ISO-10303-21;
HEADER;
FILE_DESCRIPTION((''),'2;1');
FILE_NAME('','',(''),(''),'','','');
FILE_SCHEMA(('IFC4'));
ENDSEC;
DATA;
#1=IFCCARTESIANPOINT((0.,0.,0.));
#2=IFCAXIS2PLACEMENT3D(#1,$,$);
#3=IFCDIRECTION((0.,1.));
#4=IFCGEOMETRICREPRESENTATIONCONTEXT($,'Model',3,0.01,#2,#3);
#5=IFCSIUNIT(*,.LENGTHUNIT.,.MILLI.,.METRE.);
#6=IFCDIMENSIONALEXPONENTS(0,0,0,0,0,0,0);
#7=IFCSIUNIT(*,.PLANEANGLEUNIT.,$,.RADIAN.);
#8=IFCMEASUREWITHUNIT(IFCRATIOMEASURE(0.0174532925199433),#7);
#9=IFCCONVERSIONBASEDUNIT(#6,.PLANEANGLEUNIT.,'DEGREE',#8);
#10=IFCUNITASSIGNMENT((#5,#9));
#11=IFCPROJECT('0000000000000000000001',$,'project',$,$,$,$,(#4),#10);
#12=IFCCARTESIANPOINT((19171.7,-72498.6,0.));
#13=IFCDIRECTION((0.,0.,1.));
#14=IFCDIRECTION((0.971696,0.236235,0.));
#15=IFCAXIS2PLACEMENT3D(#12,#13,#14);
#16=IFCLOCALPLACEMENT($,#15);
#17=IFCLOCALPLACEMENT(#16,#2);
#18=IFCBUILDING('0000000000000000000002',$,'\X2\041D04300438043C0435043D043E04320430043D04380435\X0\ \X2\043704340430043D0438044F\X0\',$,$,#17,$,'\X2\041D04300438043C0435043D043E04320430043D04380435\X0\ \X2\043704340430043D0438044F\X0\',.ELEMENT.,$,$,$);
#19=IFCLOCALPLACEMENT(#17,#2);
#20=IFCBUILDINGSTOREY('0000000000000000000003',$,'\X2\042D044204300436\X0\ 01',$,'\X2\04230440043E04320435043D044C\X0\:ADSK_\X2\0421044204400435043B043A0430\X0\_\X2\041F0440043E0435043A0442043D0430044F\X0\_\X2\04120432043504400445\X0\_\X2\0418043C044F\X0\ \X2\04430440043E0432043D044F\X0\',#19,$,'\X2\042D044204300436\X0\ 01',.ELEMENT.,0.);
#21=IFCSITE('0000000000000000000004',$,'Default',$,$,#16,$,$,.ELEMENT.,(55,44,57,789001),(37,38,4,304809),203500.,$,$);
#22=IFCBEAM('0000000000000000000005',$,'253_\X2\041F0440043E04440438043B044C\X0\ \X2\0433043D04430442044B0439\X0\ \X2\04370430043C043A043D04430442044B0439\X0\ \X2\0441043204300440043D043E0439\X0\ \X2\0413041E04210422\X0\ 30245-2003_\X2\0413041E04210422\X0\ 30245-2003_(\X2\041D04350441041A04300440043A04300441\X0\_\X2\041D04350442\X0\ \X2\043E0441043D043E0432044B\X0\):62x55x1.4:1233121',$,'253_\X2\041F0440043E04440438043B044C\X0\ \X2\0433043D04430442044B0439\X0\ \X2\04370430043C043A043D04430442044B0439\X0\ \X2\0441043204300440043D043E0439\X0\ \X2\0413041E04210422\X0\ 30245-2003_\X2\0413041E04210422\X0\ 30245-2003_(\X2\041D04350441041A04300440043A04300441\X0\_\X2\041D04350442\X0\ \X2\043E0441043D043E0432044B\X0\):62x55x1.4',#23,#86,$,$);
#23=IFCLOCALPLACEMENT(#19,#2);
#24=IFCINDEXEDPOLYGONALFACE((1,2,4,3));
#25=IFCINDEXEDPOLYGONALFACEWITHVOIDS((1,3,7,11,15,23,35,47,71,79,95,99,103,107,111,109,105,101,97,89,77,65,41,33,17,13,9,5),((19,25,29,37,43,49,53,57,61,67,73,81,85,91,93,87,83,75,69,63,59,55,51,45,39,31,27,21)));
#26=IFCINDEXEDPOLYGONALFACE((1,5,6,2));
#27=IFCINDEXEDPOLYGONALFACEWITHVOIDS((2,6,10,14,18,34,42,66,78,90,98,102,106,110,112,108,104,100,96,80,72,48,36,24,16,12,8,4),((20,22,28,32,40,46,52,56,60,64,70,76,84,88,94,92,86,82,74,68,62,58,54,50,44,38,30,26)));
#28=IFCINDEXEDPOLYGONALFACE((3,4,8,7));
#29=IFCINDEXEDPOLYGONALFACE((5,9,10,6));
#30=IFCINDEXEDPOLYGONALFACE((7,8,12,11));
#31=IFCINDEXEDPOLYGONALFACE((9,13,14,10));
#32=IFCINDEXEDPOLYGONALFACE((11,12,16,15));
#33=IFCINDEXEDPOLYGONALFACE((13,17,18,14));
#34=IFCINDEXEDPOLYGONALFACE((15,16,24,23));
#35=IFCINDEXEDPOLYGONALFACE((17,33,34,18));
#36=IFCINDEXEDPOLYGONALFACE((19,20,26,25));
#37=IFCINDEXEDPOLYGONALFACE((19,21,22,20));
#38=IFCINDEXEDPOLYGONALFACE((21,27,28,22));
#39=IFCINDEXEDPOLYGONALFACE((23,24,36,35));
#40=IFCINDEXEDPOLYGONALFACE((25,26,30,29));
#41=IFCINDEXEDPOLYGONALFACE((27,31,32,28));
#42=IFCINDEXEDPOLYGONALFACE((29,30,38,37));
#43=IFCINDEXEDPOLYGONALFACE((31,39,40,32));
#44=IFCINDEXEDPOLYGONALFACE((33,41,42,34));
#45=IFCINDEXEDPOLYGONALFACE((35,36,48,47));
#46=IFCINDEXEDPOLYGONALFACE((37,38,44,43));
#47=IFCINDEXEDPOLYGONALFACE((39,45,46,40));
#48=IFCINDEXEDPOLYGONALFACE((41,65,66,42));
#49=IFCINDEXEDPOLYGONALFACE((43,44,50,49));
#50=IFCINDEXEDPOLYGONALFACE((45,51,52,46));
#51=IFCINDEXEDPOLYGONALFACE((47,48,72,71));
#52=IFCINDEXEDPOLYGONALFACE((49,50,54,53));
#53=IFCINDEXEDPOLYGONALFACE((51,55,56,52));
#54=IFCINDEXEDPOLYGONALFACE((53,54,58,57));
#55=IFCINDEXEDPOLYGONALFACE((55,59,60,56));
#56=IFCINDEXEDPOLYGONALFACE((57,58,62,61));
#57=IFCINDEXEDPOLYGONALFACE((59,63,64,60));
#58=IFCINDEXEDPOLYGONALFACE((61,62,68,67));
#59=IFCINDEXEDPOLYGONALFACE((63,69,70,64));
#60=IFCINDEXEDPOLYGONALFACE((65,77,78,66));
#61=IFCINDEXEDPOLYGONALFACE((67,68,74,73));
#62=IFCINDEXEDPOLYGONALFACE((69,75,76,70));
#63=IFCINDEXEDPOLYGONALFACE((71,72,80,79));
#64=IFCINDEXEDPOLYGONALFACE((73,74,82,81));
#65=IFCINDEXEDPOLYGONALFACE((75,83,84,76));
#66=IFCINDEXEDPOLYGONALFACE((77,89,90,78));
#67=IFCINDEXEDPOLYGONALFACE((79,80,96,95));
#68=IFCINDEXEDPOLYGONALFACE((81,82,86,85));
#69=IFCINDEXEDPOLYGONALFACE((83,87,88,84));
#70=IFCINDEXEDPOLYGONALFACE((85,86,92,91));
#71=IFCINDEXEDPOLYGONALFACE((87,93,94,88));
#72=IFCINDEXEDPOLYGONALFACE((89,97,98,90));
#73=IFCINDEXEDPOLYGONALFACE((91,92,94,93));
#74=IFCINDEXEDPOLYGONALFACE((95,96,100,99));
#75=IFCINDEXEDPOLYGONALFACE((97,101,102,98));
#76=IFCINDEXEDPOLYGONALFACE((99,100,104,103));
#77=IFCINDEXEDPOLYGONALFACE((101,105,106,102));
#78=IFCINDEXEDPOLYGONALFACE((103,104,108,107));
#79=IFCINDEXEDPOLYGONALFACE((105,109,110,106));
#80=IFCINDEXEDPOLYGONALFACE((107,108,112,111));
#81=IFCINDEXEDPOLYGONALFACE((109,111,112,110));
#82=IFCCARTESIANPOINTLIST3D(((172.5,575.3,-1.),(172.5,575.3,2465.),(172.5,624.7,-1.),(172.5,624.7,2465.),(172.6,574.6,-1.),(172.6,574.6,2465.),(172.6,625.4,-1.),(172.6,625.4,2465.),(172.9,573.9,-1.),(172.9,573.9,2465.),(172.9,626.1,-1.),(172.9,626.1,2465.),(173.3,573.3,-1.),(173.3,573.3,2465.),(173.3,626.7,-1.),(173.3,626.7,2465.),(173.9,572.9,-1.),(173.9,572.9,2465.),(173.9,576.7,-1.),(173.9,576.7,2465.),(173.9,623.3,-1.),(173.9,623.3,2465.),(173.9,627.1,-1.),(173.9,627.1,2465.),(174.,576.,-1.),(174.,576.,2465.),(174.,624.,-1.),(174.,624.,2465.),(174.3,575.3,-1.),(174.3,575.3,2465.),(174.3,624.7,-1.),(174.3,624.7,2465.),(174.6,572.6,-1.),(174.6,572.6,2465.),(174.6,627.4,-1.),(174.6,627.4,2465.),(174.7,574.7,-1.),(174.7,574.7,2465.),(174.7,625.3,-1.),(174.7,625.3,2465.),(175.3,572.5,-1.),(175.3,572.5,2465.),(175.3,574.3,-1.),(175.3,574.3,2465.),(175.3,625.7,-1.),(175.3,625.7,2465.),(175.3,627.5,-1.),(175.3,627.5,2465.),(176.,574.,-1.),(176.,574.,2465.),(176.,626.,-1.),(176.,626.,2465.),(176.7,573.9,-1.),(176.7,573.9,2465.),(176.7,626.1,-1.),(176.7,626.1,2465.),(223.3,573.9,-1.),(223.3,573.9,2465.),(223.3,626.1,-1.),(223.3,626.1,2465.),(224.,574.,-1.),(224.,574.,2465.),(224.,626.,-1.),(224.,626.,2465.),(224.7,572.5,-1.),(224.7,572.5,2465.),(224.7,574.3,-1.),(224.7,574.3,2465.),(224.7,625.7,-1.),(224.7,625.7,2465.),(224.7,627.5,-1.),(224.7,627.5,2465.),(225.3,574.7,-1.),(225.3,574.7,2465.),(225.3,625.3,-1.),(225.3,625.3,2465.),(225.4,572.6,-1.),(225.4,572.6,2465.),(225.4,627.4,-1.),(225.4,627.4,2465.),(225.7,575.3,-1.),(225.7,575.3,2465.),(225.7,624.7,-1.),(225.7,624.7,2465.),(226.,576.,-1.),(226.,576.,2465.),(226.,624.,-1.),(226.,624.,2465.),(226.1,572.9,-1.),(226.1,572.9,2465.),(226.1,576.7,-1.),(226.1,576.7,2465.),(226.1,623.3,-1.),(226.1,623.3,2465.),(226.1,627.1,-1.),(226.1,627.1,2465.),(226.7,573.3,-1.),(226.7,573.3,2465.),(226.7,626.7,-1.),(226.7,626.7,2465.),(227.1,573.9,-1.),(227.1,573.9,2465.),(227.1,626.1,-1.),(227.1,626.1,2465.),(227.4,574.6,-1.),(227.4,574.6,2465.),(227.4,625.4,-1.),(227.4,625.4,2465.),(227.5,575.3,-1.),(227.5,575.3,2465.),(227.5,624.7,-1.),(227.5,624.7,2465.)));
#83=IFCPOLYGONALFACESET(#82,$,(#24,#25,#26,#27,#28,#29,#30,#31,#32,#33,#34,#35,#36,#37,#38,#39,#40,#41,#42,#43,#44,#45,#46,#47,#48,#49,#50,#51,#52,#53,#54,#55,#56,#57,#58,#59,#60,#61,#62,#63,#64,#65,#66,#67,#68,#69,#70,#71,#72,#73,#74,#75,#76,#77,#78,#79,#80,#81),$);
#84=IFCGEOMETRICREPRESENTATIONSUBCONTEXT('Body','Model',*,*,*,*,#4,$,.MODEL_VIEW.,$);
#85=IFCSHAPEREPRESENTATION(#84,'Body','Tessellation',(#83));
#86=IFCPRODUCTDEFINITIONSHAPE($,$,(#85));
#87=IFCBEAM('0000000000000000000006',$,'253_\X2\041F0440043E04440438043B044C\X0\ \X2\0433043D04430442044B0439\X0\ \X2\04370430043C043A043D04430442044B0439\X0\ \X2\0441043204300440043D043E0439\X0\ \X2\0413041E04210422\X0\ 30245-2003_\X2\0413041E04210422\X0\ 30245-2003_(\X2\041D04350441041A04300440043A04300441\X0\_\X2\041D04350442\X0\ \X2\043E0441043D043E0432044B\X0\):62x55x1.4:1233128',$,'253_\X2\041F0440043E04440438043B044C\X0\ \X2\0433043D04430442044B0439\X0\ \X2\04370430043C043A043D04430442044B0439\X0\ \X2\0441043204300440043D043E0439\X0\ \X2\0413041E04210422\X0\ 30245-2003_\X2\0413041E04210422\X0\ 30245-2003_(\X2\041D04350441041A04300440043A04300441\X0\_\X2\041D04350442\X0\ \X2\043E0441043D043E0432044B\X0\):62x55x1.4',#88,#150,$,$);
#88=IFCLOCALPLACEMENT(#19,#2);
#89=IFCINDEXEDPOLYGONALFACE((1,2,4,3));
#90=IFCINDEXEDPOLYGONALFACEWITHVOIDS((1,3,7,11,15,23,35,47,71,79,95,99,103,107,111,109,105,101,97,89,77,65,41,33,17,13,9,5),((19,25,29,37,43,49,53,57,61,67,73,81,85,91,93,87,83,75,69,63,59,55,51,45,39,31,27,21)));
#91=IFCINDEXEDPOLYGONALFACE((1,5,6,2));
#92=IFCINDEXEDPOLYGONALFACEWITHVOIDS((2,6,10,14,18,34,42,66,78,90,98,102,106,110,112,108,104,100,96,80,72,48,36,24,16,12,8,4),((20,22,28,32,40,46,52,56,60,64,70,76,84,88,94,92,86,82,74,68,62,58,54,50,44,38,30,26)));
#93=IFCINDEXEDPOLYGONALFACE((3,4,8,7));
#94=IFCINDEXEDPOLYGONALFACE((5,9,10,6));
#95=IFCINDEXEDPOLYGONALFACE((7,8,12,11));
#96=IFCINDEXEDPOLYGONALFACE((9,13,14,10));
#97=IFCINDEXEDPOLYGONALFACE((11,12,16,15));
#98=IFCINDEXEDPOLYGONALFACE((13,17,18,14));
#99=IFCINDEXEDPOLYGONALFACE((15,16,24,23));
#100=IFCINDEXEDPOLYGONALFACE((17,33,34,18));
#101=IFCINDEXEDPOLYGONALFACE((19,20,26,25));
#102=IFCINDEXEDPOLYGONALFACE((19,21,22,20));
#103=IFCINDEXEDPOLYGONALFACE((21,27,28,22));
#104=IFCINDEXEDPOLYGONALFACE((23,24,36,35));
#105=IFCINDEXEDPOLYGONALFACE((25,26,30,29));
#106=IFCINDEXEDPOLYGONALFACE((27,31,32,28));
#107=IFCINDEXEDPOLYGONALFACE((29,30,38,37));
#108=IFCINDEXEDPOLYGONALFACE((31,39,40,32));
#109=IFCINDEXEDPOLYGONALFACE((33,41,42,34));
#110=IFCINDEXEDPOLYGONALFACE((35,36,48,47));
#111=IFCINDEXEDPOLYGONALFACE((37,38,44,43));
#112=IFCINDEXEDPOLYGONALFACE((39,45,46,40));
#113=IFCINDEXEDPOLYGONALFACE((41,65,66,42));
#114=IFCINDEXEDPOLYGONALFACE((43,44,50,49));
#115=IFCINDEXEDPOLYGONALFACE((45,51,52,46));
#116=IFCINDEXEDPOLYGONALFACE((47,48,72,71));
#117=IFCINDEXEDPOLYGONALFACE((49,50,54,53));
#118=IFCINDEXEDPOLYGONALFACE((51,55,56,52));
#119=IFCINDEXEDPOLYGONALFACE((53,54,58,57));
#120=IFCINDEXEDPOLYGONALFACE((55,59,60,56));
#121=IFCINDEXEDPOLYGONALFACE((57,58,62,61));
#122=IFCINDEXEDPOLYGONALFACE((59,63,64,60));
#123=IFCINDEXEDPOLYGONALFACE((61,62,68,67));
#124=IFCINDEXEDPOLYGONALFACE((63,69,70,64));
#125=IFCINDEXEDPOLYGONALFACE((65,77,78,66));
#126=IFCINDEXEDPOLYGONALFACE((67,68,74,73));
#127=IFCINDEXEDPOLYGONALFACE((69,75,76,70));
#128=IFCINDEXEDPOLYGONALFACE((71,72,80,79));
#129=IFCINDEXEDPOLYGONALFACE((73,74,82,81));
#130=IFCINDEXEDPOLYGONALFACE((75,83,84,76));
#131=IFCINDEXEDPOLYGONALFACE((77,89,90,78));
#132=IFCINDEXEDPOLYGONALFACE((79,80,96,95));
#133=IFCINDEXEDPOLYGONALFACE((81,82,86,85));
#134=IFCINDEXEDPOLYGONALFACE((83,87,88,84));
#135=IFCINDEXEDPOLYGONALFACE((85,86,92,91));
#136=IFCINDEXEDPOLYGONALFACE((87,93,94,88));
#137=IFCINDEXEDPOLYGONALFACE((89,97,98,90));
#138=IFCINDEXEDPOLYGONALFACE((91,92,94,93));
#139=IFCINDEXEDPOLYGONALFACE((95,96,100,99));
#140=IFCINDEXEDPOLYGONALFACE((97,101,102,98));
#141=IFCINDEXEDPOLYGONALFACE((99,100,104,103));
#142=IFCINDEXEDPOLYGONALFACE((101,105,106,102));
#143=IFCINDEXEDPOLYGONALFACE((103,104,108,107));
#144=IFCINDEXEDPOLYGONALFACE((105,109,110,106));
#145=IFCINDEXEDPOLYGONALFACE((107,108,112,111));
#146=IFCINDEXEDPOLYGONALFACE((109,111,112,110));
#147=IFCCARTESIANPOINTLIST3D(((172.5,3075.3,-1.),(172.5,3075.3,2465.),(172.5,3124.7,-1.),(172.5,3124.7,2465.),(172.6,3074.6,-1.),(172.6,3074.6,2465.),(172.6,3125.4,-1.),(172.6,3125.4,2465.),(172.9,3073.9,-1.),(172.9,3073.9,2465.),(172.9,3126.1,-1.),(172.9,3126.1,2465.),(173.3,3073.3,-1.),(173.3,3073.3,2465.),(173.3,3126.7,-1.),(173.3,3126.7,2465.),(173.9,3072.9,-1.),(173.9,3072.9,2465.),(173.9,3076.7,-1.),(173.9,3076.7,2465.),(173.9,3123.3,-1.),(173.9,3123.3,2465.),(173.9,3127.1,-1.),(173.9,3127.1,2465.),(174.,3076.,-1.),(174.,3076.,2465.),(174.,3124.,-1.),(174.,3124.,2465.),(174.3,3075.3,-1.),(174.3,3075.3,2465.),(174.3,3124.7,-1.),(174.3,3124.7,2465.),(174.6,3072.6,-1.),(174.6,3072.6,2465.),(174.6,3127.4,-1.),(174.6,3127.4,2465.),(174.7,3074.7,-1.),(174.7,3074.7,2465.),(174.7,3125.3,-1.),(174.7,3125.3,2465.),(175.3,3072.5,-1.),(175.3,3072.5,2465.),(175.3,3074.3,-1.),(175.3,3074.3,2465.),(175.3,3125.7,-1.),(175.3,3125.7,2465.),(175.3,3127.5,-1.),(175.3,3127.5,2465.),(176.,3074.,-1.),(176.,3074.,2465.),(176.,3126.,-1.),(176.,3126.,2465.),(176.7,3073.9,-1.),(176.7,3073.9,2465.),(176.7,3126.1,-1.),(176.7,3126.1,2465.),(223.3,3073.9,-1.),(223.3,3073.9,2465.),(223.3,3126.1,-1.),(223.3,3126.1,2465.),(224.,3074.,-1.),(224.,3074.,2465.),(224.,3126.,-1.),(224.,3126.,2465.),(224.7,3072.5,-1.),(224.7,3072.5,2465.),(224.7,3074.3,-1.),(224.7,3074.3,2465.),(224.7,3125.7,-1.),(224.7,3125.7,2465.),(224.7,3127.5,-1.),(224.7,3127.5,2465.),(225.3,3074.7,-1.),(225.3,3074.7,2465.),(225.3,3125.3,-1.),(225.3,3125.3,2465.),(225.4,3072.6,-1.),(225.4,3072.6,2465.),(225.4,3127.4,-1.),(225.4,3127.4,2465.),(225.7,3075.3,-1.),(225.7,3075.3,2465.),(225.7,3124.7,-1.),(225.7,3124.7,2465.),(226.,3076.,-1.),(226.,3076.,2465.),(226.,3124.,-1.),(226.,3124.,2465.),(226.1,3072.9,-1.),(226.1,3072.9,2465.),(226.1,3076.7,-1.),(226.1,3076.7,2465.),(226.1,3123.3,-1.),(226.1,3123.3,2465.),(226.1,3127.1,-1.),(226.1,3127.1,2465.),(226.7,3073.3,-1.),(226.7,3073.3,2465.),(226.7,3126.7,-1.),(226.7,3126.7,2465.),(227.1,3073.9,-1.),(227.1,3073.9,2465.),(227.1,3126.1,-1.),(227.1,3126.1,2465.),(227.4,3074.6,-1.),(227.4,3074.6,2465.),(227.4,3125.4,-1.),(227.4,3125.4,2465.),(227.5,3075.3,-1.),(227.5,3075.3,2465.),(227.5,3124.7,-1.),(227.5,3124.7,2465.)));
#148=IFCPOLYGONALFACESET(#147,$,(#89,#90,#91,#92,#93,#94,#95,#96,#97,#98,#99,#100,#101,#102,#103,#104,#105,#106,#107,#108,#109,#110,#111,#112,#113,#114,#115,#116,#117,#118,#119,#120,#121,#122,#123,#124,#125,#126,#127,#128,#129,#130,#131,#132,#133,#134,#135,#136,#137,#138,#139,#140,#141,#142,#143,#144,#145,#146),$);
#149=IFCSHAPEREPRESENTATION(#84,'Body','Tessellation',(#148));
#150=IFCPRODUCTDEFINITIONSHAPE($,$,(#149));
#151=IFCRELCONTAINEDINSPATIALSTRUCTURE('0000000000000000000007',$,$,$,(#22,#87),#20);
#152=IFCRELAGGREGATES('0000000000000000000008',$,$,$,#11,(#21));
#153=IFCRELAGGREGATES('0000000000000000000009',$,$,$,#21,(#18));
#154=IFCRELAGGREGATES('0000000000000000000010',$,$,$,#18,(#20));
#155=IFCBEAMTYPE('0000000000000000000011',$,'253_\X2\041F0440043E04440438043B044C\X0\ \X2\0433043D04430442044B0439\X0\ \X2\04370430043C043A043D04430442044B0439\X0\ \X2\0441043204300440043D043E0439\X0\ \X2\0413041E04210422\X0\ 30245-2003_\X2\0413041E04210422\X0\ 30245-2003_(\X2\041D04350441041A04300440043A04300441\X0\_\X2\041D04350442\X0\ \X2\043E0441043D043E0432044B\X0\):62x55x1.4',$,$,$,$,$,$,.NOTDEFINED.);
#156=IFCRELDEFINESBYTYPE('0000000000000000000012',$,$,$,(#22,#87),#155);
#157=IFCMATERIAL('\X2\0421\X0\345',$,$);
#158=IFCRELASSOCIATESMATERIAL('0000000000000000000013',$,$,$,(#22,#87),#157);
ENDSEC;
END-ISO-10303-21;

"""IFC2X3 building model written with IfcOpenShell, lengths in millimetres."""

from ifc_helpers import new_model, entity, si_unit, converted_unit, direction, frame, frame_2d, origin, place, context, subcontext, project, spatial, polyline, circle_curve, parameter, trimmed, segment, composite_curve, outline, extrude, material, type_object, element, save


model = new_model("IFC2X3")

# Units and contexts
model_context = context("Model", 3, precision=0.01, world=origin(), true_north=direction((0.0, 1.0)))
body_context = subcontext(model_context, "Body", "Model", "MODEL_VIEW")
ifc_project = project(units=[si_unit("LENGTHUNIT", "METRE", prefix="MILLI"), converted_unit("PLANEANGLEUNIT", "DEGREE", entity("IfcRatioMeasure", 0.0174532925199433), si_unit("PLANEANGLEUNIT", "RADIAN"), dimensions=[0, 0, 0, 0, 0, 0, 0])], contexts=[model_context])

# Site, building, storey
site_placement = place(None, frame((19171.7, -72498.6, 0.0), z_axis=(0.0, 0.0, 1.0), x_axis=(0.971696, 0.236235, 0.0)))
site = spatial("IfcSite", under=ifc_project, at=site_placement, Name="Default", CompositionType="ELEMENT", RefLatitude=(55, 44, 57, 789001), RefLongitude=(37, 38, 4, 304809), RefElevation=203500.0)
building_placement = place(site_placement, origin())
building = spatial("IfcBuilding", under=site, at=building_placement, Name="Наименование здания", LongName="Наименование здания", CompositionType="ELEMENT")
storey_placement = place(building_placement, origin())
storey = spatial("IfcBuildingStorey", under=building, at=storey_placement, Name="Этаж 01", ObjectType="Уровень:ADSK_Стрелка_Проектная_Вверх_Имя уровня", LongName="Этаж 01", CompositionType="ELEMENT", Elevation=0.0)

# Beams
ifc_material_1 = material(Name="С345")
beam_type_1 = type_object("IfcBeamType", Name="253_Профиль гнутый замкнутый сварной ГОСТ 30245-2003_ГОСТ 30245-2003_(НесКаркас_Нет основы):62x55x1.4", PredefinedType="NOTDEFINED")
beam_1_placement = place(storey_placement, frame((170.9, 570.9, -1.0), z_axis=(1.0, 0.0, 0.0), x_axis=(0.0, 0.0, 1.0)))
element("IfcBeam", 1, at=beam_1_placement, inside=storey, type_object=beam_type_1, material=ifc_material_1, Name="253_Профиль гнутый замкнутый сварной ГОСТ 30245-2003_ГОСТ 30245-2003_(НесКаркас_Нет основы):62x55x1.4:1233121", ObjectType="253_Профиль гнутый замкнутый сварной ГОСТ 30245-2003_ГОСТ 30245-2003_(НесКаркас_Нет основы):62x55x1.4", context=body_context, shape_type="SweptSolid", body=[
    extrude(outline(composite_curve([segment(trimmed(circle_curve(frame_2d((24.7, -24.7), x_axis=(1.0, 0.0)), 2.8), [parameter(270.0)], [parameter(0.0)], True, "PARAMETER"), True, "CONTINUOUS"), segment(polyline([(27.5, -24.7), (27.5, 24.7)]), True, "CONTINUOUS"), segment(trimmed(circle_curve(frame_2d((24.7, 24.7), x_axis=(1.0, 0.0)), 2.8), [parameter(0.0)], [parameter(90.0)], True, "PARAMETER"), True, "CONTINUOUS"), segment(polyline([(24.7, 27.5), (-24.7, 27.5)]), True, "CONTINUOUS"), segment(trimmed(circle_curve(frame_2d((-24.7, 24.7), x_axis=(1.0, 0.0)), 2.8), [parameter(90.0)], [parameter(180.0)], True, "PARAMETER"), True, "CONTINUOUS"), segment(polyline([(-27.5, 24.7), (-27.5, -24.7)]), True, "CONTINUOUS"), segment(trimmed(circle_curve(frame_2d((-24.7, -24.7), x_axis=(1.0, 0.0)), 2.8), [parameter(180.0)], [parameter(270.0)], True, "PARAMETER"), True, "CONTINUOUS"), segment(polyline([(-24.7, -27.5), (24.7, -27.5)]), True, "CONTINUOUS")], self_intersect=False), holes=[composite_curve([segment(polyline([(23.3, -26.1), (-23.3, -26.1)]), True, "CONTINUOUS"), segment(trimmed(circle_curve(frame_2d((-23.3, -23.3), x_axis=(1.0, 0.0)), 2.8), [parameter(180.0)], [parameter(270.0)], True, "PARAMETER"), False, "CONTINUOUS"), segment(polyline([(-26.1, -23.3), (-26.1, 23.3)]), True, "CONTINUOUS"), segment(trimmed(circle_curve(frame_2d((-23.3, 23.3), x_axis=(1.0, 0.0)), 2.8), [parameter(90.0)], [parameter(180.0)], True, "PARAMETER"), False, "CONTINUOUS"), segment(polyline([(-23.3, 26.1), (23.3, 26.1)]), True, "CONTINUOUS"), segment(trimmed(circle_curve(frame_2d((23.3, 23.3), x_axis=(1.0, 0.0)), 2.8), [parameter(0.0)], [parameter(90.0)], True, "PARAMETER"), False, "CONTINUOUS"), segment(polyline([(26.1, 23.3), (26.1, -23.3)]), True, "CONTINUOUS"), segment(trimmed(circle_curve(frame_2d((23.3, -23.3), x_axis=(1.0, 0.0)), 2.8), [parameter(270.0)], [parameter(0.0)], True, "PARAMETER"), False, "CONTINUOUS")], self_intersect=False)]), frame((0.0, -29.1, 29.1), z_axis=(1.0, 0.0, 0.0), x_axis=(0.0, -1.0, 0.0)), (0.0, 0.0, 1.0), 2466.0),
])
beam_2_placement = place(storey_placement, frame((170.9, 3070.9, -1.0), z_axis=(1.0, 0.0, 0.0), x_axis=(0.0, 0.0, 1.0)))
element("IfcBeam", 2, at=beam_2_placement, inside=storey, type_object=beam_type_1, material=ifc_material_1, Name="253_Профиль гнутый замкнутый сварной ГОСТ 30245-2003_ГОСТ 30245-2003_(НесКаркас_Нет основы):62x55x1.4:1233128", ObjectType="253_Профиль гнутый замкнутый сварной ГОСТ 30245-2003_ГОСТ 30245-2003_(НесКаркас_Нет основы):62x55x1.4", context=body_context, shape_type="SweptSolid", body=[
    extrude(outline(composite_curve([segment(trimmed(circle_curve(frame_2d((24.7, -24.7), x_axis=(1.0, 0.0)), 2.8), [parameter(270.0)], [parameter(0.0)], True, "PARAMETER"), True, "CONTINUOUS"), segment(polyline([(27.5, -24.7), (27.5, 24.7)]), True, "CONTINUOUS"), segment(trimmed(circle_curve(frame_2d((24.7, 24.7), x_axis=(1.0, 0.0)), 2.8), [parameter(0.0)], [parameter(90.0)], True, "PARAMETER"), True, "CONTINUOUS"), segment(polyline([(24.7, 27.5), (-24.7, 27.5)]), True, "CONTINUOUS"), segment(trimmed(circle_curve(frame_2d((-24.7, 24.7), x_axis=(1.0, 0.0)), 2.8), [parameter(90.0)], [parameter(180.0)], True, "PARAMETER"), True, "CONTINUOUS"), segment(polyline([(-27.5, 24.7), (-27.5, -24.7)]), True, "CONTINUOUS"), segment(trimmed(circle_curve(frame_2d((-24.7, -24.7), x_axis=(1.0, 0.0)), 2.8), [parameter(180.0)], [parameter(270.0)], True, "PARAMETER"), True, "CONTINUOUS"), segment(polyline([(-24.7, -27.5), (24.7, -27.5)]), True, "CONTINUOUS")], self_intersect=False), holes=[composite_curve([segment(polyline([(23.3, -26.1), (-23.3, -26.1)]), True, "CONTINUOUS"), segment(trimmed(circle_curve(frame_2d((-23.3, -23.3), x_axis=(1.0, 0.0)), 2.8), [parameter(180.0)], [parameter(270.0)], True, "PARAMETER"), False, "CONTINUOUS"), segment(polyline([(-26.1, -23.3), (-26.1, 23.3)]), True, "CONTINUOUS"), segment(trimmed(circle_curve(frame_2d((-23.3, 23.3), x_axis=(1.0, 0.0)), 2.8), [parameter(90.0)], [parameter(180.0)], True, "PARAMETER"), False, "CONTINUOUS"), segment(polyline([(-23.3, 26.1), (23.3, 26.1)]), True, "CONTINUOUS"), segment(trimmed(circle_curve(frame_2d((23.3, 23.3), x_axis=(1.0, 0.0)), 2.8), [parameter(0.0)], [parameter(90.0)], True, "PARAMETER"), False, "CONTINUOUS"), segment(polyline([(26.1, 23.3), (26.1, -23.3)]), True, "CONTINUOUS"), segment(trimmed(circle_curve(frame_2d((23.3, -23.3), x_axis=(1.0, 0.0)), 2.8), [parameter(270.0)], [parameter(0.0)], True, "PARAMETER"), False, "CONTINUOUS")], self_intersect=False)]), frame((0.0, -29.1, 29.1), z_axis=(1.0, 0.0, 0.0), x_axis=(0.0, -1.0, 0.0)), (0.0, 0.0, 1.0), 2466.0),
])

save(model, "model.ifc")
